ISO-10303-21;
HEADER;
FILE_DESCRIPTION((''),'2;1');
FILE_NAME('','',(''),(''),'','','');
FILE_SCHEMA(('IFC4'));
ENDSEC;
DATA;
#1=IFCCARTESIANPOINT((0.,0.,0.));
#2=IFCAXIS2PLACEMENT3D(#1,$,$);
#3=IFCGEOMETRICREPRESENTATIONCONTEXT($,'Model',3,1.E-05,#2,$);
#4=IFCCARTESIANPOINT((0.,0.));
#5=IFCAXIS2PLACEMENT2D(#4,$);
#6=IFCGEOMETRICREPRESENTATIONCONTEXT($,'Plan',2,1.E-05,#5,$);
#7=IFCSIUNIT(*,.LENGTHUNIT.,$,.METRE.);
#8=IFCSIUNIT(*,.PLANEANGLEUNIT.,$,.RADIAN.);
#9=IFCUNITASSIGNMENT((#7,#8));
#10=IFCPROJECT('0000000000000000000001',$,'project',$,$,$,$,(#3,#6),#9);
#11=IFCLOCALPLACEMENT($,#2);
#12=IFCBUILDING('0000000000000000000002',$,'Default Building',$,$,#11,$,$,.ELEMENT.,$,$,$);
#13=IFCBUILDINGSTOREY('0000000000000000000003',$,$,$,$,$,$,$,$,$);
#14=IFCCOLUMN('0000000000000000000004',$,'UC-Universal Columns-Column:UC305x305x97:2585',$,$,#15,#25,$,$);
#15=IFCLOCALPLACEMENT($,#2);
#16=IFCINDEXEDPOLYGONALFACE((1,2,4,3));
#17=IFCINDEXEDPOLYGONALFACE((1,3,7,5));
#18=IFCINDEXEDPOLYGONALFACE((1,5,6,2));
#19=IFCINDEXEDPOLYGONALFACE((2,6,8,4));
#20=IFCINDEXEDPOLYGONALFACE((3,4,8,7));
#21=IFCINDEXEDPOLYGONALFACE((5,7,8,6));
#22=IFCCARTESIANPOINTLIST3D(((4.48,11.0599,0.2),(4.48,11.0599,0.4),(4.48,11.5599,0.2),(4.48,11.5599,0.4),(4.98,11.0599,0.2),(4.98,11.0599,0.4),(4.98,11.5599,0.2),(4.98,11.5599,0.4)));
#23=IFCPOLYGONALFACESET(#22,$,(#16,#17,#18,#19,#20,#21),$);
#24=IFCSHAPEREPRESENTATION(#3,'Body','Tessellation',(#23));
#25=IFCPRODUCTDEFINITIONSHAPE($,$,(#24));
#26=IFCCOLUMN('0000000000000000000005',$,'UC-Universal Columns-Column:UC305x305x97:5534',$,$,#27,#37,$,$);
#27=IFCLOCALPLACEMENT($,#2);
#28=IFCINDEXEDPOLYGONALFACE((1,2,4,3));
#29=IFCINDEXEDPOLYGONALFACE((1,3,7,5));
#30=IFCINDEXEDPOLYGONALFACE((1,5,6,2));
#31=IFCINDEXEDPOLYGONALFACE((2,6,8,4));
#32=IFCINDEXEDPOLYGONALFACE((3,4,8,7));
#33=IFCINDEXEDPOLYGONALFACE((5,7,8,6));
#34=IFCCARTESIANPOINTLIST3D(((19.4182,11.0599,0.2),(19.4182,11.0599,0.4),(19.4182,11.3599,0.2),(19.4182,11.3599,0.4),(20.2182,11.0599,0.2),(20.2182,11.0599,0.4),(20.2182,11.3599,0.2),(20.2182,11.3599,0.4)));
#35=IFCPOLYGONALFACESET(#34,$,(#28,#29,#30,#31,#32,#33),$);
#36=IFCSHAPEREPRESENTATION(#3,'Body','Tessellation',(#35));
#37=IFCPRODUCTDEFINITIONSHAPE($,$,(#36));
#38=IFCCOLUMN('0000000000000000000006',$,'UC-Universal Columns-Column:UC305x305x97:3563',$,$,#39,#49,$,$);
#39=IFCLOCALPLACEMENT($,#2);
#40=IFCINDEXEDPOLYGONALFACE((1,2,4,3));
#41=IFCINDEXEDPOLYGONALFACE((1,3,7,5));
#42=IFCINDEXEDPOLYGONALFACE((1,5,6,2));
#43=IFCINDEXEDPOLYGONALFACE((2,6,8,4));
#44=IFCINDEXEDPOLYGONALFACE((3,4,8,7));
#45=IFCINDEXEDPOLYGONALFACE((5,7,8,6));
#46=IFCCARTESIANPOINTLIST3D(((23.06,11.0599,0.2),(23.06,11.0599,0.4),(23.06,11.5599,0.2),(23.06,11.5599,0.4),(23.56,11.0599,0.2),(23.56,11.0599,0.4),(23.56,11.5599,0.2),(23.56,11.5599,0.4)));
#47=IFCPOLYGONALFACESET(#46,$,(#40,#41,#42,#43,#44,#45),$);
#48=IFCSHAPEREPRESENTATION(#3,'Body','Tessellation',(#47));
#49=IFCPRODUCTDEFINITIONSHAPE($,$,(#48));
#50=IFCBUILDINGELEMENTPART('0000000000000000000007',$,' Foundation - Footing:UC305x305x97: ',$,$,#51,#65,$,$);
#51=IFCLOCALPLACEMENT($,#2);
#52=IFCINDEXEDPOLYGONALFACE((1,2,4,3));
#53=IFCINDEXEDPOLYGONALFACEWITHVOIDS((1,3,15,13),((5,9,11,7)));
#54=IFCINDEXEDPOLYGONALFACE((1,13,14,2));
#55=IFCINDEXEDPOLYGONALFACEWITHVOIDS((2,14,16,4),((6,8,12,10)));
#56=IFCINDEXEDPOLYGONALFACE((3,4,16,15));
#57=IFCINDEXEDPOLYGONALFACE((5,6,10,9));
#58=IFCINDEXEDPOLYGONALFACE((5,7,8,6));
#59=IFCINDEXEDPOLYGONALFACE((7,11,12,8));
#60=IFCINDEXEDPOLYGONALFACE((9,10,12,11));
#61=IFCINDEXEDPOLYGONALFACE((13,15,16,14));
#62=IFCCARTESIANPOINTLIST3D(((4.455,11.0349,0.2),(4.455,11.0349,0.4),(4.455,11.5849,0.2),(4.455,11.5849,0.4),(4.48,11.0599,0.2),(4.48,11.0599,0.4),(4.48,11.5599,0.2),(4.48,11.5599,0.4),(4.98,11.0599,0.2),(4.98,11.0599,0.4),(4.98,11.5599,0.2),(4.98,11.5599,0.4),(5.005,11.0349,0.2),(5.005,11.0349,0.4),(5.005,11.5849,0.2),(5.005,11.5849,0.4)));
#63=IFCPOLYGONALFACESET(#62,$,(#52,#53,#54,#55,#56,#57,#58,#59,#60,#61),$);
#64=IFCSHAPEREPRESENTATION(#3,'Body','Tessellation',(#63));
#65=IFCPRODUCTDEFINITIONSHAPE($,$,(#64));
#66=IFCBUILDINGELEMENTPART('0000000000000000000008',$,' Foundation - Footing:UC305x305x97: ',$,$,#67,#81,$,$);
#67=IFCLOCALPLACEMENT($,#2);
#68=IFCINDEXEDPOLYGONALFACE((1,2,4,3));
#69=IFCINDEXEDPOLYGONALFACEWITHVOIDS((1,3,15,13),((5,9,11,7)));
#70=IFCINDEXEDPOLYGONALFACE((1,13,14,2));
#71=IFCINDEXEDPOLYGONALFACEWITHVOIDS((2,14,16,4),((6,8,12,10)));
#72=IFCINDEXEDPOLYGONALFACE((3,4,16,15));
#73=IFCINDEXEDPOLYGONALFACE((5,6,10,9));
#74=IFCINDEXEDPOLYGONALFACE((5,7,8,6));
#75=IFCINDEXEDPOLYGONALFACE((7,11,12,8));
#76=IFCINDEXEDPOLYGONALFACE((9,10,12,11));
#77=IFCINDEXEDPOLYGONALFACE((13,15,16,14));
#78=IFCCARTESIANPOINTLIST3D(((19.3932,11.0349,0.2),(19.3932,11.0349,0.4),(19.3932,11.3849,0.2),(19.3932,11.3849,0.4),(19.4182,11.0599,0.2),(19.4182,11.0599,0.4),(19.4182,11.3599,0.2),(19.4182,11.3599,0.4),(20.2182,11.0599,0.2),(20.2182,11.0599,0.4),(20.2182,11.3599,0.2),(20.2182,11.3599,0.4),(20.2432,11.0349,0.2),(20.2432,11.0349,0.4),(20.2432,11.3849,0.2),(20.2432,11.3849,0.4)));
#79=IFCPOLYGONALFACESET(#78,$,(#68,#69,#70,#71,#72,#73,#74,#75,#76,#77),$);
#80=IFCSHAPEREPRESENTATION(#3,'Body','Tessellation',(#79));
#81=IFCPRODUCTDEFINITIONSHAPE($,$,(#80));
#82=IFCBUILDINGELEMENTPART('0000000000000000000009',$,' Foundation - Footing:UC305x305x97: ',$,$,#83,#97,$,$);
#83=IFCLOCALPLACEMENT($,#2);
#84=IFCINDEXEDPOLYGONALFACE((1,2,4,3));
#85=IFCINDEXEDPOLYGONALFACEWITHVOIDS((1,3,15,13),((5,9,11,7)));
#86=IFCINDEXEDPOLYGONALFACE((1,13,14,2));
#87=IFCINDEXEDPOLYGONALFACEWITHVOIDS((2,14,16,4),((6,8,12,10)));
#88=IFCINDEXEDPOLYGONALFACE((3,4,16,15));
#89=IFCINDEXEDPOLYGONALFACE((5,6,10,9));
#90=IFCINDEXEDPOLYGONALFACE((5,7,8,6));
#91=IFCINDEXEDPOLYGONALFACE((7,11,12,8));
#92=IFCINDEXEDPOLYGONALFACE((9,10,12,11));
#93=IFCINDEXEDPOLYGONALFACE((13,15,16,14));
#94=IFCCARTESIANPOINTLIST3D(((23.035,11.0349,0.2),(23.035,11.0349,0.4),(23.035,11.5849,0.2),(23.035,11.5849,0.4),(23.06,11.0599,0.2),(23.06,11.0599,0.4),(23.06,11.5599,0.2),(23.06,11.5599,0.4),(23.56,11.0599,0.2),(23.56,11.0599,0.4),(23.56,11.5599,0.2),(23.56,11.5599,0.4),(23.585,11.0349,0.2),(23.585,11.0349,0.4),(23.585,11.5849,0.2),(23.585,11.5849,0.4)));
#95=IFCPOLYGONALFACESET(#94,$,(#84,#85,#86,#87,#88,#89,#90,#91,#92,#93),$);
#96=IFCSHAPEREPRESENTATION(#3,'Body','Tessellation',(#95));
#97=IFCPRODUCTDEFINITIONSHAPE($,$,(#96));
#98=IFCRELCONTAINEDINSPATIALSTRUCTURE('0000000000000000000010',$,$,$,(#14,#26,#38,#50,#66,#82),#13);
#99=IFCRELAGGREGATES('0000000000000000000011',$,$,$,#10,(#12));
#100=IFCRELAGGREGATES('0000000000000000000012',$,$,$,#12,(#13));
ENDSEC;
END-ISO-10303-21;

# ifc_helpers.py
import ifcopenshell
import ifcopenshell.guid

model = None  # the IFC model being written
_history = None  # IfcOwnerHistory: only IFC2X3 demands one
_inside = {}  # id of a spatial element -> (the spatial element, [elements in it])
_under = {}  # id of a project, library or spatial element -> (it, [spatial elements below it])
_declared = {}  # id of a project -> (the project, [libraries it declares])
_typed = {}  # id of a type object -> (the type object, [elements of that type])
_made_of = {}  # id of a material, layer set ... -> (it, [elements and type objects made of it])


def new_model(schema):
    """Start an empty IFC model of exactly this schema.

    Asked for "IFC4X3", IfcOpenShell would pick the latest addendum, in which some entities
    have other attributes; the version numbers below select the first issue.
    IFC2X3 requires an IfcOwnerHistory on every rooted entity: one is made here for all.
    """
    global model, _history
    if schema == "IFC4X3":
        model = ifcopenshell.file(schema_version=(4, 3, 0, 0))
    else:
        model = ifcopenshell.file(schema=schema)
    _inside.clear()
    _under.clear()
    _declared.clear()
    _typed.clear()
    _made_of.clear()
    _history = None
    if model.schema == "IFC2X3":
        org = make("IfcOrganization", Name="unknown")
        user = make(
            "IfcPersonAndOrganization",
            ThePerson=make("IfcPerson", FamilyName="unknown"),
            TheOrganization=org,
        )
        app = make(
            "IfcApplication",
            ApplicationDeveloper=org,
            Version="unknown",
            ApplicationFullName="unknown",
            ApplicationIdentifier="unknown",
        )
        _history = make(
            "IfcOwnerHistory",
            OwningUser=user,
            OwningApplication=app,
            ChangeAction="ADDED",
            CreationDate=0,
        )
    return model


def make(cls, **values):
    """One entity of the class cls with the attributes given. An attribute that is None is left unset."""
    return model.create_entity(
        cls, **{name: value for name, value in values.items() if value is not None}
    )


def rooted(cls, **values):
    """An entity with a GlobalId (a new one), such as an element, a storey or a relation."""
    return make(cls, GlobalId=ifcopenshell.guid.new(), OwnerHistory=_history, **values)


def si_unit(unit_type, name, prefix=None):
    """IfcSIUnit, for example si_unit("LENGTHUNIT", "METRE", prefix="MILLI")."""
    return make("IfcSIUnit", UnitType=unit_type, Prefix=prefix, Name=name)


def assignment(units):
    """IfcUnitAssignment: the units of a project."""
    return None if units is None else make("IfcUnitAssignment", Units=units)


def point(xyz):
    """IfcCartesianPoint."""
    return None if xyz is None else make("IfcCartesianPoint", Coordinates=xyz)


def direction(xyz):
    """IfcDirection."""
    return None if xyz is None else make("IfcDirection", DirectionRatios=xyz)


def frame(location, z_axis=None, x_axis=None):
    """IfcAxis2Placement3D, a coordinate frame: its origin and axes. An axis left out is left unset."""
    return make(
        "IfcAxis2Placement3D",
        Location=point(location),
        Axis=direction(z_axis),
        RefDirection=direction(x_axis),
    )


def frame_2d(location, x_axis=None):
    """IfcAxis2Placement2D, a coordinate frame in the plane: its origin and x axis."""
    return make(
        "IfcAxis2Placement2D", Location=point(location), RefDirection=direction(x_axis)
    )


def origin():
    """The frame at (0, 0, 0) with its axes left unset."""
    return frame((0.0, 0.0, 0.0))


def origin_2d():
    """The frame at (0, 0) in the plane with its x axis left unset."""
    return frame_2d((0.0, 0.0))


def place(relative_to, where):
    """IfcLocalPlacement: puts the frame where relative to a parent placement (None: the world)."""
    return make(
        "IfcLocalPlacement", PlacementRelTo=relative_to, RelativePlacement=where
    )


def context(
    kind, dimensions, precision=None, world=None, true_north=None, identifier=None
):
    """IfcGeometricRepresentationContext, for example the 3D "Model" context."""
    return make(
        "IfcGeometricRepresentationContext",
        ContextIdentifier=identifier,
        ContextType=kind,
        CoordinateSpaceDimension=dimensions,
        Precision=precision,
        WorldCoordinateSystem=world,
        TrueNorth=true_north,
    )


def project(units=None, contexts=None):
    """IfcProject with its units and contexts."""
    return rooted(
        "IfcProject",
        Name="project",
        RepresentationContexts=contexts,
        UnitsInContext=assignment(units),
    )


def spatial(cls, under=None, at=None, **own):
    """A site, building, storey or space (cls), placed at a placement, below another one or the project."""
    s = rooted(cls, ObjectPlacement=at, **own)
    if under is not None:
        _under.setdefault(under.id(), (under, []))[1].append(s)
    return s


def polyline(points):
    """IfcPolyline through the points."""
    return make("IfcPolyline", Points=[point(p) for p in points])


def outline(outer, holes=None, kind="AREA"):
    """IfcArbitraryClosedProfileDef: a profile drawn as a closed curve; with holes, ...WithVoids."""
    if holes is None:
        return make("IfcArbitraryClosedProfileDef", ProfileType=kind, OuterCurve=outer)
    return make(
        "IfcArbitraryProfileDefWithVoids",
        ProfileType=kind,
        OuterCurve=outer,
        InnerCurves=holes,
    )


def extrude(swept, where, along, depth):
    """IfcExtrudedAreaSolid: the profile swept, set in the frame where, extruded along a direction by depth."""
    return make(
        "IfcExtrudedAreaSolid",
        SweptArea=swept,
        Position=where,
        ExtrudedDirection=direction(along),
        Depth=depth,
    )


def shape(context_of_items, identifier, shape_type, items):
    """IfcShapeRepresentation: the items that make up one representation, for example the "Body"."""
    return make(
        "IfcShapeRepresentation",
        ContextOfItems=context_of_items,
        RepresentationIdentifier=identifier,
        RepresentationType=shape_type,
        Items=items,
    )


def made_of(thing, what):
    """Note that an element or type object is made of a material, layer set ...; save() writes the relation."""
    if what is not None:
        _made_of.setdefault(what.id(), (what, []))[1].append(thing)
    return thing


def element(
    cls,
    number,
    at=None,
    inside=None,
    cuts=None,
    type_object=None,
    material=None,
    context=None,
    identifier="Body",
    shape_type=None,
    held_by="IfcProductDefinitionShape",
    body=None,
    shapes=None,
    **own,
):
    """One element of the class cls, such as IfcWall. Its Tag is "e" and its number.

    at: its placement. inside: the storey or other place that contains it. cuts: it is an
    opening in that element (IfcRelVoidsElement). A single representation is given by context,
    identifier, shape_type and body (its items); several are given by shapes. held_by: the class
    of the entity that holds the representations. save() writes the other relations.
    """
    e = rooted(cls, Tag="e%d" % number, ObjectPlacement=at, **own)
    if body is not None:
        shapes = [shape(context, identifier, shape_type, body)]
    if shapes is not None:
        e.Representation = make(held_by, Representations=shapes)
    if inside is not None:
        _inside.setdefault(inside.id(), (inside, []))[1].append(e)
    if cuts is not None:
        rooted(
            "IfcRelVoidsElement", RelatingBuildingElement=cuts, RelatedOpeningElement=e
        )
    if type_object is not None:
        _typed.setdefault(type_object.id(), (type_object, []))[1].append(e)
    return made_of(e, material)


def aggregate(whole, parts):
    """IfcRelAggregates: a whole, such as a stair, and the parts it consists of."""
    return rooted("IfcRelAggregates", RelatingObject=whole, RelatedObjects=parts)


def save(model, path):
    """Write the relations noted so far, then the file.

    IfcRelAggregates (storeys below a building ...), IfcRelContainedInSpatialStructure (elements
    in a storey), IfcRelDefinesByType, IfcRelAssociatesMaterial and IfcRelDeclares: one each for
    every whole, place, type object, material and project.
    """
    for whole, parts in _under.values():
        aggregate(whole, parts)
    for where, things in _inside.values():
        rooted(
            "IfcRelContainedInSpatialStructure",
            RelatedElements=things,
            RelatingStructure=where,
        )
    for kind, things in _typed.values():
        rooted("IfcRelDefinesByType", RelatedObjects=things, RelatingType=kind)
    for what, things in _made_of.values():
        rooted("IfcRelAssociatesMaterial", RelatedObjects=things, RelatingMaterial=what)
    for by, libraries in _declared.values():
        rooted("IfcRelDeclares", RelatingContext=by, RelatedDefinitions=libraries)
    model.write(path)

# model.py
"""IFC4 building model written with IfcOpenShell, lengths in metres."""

from ifc_helpers import new_model, si_unit, origin, origin_2d, place, context, project, spatial, polyline, outline, extrude, element, save


model = new_model("IFC4")

# Units and contexts
model_context = context("Model", 3, precision=1e-05, world=origin())
plan_context = context("Plan", 2, precision=1e-05, world=origin_2d())
ifc_project = project(units=[si_unit("LENGTHUNIT", "METRE"), si_unit("PLANEANGLEUNIT", "RADIAN")], contexts=[model_context, plan_context])

# Building, storey
building_placement = place(None, origin())
building = spatial("IfcBuilding", under=ifc_project, at=building_placement, Name="Default Building", CompositionType="ELEMENT")
storey = spatial("IfcBuildingStorey", under=building)

# Columns
element("IfcColumn", 1, inside=storey, Name="UC-Universal Columns-Column:UC305x305x97:2585", context=model_context, shape_type="SweptSolid", body=[
    extrude(outline(polyline([(4.98, 11.0599, 0.2), (4.48, 11.0599, 0.2), (4.48, 11.5599, 0.2), (4.98, 11.5599, 0.2), (4.98, 11.0599, 0.2)])), None, (0.0, 0.0, 1.0), 0.2),
])
element("IfcColumn", 2, inside=storey, Name="UC-Universal Columns-Column:UC305x305x97:5534", context=model_context, shape_type="SweptSolid", body=[
    extrude(outline(polyline([(19.4182, 11.0599, 0.2), (20.2182, 11.0599, 0.2), (20.2182, 11.3599, 0.2), (19.4182, 11.3599, 0.2), (19.4182, 11.0599, 0.2)])), None, (0.0, 0.0, 1.0), 0.2),
])
element("IfcColumn", 3, inside=storey, Name="UC-Universal Columns-Column:UC305x305x97:3563", context=model_context, shape_type="SweptSolid", body=[
    extrude(outline(polyline([(23.06, 11.0599, 0.2), (23.56, 11.0599, 0.2), (23.56, 11.5599, 0.2), (23.06, 11.5599, 0.2), (23.06, 11.0599, 0.2)])), None, (0.0, 0.0, 1.0), 0.2),
])

# Building element parts, openings
building_element_part_1 = element("IfcBuildingElementPart", 4, inside=storey, Name=" Foundation - Footing:UC305x305x97: ", context=model_context, shape_type="SweptSolid", body=[
    extrude(outline(polyline([(5.005, 11.0349, 0.2), (4.455, 11.0349, 0.2), (4.455, 11.5849, 0.2), (5.005, 11.5849, 0.2), (5.005, 11.0349, 0.2)])), None, (0.0, 0.0, 1.0), 0.2),
])
element("IfcOpeningElement", 5, inside=storey, cuts=building_element_part_1, context=model_context, shape_type="SweptSolid", body=[
    extrude(outline(polyline([(4.98, 11.0599, 0.2), (4.48, 11.0599, 0.2), (4.48, 11.5599, 0.2), (4.98, 11.5599, 0.2), (4.98, 11.0599, 0.2)])), None, (0.0, 0.0, 1.0), 0.2),
])
building_element_part_2 = element("IfcBuildingElementPart", 6, inside=storey, Name=" Foundation - Footing:UC305x305x97: ", context=model_context, shape_type="SweptSolid", body=[
    extrude(outline(polyline([(19.3932, 11.0349, 0.2), (20.2432, 11.0349, 0.2), (20.2432, 11.3849, 0.2), (19.3932, 11.3849, 0.2), (19.3932, 11.0349, 0.2)])), None, (0.0, 0.0, 1.0), 0.2),
])
element("IfcOpeningElement", 7, inside=storey, cuts=building_element_part_2, context=model_context, shape_type="SweptSolid", body=[
    extrude(outline(polyline([(19.4182, 11.0599, 0.2), (20.2182, 11.0599, 0.2), (20.2182, 11.3599, 0.2), (19.4182, 11.3599, 0.2), (19.4182, 11.0599, 0.2)])), None, (0.0, 0.0, 1.0), 0.2),
])
building_element_part_3 = element("IfcBuildingElementPart", 8, inside=storey, Name=" Foundation - Footing:UC305x305x97: ", context=model_context, shape_type="SweptSolid", body=[
    extrude(outline(polyline([(23.035, 11.0349, 0.2), (23.585, 11.0349, 0.2), (23.585, 11.5849, 0.2), (23.035, 11.5849, 0.2), (23.035, 11.0349, 0.2)])), None, (0.0, 0.0, 1.0), 0.2),
])
element("IfcOpeningElement", 9, inside=storey, cuts=building_element_part_3, context=model_context, shape_type="SweptSolid", body=[
    extrude(outline(polyline([(23.06, 11.0599, 0.2), (23.56, 11.0599, 0.2), (23.56, 11.5599, 0.2), (23.06, 11.5599, 0.2), (23.06, 11.0599, 0.2)])), None, (0.0, 0.0, 1.0), 0.2),
])

save(model, "model.ifc")
